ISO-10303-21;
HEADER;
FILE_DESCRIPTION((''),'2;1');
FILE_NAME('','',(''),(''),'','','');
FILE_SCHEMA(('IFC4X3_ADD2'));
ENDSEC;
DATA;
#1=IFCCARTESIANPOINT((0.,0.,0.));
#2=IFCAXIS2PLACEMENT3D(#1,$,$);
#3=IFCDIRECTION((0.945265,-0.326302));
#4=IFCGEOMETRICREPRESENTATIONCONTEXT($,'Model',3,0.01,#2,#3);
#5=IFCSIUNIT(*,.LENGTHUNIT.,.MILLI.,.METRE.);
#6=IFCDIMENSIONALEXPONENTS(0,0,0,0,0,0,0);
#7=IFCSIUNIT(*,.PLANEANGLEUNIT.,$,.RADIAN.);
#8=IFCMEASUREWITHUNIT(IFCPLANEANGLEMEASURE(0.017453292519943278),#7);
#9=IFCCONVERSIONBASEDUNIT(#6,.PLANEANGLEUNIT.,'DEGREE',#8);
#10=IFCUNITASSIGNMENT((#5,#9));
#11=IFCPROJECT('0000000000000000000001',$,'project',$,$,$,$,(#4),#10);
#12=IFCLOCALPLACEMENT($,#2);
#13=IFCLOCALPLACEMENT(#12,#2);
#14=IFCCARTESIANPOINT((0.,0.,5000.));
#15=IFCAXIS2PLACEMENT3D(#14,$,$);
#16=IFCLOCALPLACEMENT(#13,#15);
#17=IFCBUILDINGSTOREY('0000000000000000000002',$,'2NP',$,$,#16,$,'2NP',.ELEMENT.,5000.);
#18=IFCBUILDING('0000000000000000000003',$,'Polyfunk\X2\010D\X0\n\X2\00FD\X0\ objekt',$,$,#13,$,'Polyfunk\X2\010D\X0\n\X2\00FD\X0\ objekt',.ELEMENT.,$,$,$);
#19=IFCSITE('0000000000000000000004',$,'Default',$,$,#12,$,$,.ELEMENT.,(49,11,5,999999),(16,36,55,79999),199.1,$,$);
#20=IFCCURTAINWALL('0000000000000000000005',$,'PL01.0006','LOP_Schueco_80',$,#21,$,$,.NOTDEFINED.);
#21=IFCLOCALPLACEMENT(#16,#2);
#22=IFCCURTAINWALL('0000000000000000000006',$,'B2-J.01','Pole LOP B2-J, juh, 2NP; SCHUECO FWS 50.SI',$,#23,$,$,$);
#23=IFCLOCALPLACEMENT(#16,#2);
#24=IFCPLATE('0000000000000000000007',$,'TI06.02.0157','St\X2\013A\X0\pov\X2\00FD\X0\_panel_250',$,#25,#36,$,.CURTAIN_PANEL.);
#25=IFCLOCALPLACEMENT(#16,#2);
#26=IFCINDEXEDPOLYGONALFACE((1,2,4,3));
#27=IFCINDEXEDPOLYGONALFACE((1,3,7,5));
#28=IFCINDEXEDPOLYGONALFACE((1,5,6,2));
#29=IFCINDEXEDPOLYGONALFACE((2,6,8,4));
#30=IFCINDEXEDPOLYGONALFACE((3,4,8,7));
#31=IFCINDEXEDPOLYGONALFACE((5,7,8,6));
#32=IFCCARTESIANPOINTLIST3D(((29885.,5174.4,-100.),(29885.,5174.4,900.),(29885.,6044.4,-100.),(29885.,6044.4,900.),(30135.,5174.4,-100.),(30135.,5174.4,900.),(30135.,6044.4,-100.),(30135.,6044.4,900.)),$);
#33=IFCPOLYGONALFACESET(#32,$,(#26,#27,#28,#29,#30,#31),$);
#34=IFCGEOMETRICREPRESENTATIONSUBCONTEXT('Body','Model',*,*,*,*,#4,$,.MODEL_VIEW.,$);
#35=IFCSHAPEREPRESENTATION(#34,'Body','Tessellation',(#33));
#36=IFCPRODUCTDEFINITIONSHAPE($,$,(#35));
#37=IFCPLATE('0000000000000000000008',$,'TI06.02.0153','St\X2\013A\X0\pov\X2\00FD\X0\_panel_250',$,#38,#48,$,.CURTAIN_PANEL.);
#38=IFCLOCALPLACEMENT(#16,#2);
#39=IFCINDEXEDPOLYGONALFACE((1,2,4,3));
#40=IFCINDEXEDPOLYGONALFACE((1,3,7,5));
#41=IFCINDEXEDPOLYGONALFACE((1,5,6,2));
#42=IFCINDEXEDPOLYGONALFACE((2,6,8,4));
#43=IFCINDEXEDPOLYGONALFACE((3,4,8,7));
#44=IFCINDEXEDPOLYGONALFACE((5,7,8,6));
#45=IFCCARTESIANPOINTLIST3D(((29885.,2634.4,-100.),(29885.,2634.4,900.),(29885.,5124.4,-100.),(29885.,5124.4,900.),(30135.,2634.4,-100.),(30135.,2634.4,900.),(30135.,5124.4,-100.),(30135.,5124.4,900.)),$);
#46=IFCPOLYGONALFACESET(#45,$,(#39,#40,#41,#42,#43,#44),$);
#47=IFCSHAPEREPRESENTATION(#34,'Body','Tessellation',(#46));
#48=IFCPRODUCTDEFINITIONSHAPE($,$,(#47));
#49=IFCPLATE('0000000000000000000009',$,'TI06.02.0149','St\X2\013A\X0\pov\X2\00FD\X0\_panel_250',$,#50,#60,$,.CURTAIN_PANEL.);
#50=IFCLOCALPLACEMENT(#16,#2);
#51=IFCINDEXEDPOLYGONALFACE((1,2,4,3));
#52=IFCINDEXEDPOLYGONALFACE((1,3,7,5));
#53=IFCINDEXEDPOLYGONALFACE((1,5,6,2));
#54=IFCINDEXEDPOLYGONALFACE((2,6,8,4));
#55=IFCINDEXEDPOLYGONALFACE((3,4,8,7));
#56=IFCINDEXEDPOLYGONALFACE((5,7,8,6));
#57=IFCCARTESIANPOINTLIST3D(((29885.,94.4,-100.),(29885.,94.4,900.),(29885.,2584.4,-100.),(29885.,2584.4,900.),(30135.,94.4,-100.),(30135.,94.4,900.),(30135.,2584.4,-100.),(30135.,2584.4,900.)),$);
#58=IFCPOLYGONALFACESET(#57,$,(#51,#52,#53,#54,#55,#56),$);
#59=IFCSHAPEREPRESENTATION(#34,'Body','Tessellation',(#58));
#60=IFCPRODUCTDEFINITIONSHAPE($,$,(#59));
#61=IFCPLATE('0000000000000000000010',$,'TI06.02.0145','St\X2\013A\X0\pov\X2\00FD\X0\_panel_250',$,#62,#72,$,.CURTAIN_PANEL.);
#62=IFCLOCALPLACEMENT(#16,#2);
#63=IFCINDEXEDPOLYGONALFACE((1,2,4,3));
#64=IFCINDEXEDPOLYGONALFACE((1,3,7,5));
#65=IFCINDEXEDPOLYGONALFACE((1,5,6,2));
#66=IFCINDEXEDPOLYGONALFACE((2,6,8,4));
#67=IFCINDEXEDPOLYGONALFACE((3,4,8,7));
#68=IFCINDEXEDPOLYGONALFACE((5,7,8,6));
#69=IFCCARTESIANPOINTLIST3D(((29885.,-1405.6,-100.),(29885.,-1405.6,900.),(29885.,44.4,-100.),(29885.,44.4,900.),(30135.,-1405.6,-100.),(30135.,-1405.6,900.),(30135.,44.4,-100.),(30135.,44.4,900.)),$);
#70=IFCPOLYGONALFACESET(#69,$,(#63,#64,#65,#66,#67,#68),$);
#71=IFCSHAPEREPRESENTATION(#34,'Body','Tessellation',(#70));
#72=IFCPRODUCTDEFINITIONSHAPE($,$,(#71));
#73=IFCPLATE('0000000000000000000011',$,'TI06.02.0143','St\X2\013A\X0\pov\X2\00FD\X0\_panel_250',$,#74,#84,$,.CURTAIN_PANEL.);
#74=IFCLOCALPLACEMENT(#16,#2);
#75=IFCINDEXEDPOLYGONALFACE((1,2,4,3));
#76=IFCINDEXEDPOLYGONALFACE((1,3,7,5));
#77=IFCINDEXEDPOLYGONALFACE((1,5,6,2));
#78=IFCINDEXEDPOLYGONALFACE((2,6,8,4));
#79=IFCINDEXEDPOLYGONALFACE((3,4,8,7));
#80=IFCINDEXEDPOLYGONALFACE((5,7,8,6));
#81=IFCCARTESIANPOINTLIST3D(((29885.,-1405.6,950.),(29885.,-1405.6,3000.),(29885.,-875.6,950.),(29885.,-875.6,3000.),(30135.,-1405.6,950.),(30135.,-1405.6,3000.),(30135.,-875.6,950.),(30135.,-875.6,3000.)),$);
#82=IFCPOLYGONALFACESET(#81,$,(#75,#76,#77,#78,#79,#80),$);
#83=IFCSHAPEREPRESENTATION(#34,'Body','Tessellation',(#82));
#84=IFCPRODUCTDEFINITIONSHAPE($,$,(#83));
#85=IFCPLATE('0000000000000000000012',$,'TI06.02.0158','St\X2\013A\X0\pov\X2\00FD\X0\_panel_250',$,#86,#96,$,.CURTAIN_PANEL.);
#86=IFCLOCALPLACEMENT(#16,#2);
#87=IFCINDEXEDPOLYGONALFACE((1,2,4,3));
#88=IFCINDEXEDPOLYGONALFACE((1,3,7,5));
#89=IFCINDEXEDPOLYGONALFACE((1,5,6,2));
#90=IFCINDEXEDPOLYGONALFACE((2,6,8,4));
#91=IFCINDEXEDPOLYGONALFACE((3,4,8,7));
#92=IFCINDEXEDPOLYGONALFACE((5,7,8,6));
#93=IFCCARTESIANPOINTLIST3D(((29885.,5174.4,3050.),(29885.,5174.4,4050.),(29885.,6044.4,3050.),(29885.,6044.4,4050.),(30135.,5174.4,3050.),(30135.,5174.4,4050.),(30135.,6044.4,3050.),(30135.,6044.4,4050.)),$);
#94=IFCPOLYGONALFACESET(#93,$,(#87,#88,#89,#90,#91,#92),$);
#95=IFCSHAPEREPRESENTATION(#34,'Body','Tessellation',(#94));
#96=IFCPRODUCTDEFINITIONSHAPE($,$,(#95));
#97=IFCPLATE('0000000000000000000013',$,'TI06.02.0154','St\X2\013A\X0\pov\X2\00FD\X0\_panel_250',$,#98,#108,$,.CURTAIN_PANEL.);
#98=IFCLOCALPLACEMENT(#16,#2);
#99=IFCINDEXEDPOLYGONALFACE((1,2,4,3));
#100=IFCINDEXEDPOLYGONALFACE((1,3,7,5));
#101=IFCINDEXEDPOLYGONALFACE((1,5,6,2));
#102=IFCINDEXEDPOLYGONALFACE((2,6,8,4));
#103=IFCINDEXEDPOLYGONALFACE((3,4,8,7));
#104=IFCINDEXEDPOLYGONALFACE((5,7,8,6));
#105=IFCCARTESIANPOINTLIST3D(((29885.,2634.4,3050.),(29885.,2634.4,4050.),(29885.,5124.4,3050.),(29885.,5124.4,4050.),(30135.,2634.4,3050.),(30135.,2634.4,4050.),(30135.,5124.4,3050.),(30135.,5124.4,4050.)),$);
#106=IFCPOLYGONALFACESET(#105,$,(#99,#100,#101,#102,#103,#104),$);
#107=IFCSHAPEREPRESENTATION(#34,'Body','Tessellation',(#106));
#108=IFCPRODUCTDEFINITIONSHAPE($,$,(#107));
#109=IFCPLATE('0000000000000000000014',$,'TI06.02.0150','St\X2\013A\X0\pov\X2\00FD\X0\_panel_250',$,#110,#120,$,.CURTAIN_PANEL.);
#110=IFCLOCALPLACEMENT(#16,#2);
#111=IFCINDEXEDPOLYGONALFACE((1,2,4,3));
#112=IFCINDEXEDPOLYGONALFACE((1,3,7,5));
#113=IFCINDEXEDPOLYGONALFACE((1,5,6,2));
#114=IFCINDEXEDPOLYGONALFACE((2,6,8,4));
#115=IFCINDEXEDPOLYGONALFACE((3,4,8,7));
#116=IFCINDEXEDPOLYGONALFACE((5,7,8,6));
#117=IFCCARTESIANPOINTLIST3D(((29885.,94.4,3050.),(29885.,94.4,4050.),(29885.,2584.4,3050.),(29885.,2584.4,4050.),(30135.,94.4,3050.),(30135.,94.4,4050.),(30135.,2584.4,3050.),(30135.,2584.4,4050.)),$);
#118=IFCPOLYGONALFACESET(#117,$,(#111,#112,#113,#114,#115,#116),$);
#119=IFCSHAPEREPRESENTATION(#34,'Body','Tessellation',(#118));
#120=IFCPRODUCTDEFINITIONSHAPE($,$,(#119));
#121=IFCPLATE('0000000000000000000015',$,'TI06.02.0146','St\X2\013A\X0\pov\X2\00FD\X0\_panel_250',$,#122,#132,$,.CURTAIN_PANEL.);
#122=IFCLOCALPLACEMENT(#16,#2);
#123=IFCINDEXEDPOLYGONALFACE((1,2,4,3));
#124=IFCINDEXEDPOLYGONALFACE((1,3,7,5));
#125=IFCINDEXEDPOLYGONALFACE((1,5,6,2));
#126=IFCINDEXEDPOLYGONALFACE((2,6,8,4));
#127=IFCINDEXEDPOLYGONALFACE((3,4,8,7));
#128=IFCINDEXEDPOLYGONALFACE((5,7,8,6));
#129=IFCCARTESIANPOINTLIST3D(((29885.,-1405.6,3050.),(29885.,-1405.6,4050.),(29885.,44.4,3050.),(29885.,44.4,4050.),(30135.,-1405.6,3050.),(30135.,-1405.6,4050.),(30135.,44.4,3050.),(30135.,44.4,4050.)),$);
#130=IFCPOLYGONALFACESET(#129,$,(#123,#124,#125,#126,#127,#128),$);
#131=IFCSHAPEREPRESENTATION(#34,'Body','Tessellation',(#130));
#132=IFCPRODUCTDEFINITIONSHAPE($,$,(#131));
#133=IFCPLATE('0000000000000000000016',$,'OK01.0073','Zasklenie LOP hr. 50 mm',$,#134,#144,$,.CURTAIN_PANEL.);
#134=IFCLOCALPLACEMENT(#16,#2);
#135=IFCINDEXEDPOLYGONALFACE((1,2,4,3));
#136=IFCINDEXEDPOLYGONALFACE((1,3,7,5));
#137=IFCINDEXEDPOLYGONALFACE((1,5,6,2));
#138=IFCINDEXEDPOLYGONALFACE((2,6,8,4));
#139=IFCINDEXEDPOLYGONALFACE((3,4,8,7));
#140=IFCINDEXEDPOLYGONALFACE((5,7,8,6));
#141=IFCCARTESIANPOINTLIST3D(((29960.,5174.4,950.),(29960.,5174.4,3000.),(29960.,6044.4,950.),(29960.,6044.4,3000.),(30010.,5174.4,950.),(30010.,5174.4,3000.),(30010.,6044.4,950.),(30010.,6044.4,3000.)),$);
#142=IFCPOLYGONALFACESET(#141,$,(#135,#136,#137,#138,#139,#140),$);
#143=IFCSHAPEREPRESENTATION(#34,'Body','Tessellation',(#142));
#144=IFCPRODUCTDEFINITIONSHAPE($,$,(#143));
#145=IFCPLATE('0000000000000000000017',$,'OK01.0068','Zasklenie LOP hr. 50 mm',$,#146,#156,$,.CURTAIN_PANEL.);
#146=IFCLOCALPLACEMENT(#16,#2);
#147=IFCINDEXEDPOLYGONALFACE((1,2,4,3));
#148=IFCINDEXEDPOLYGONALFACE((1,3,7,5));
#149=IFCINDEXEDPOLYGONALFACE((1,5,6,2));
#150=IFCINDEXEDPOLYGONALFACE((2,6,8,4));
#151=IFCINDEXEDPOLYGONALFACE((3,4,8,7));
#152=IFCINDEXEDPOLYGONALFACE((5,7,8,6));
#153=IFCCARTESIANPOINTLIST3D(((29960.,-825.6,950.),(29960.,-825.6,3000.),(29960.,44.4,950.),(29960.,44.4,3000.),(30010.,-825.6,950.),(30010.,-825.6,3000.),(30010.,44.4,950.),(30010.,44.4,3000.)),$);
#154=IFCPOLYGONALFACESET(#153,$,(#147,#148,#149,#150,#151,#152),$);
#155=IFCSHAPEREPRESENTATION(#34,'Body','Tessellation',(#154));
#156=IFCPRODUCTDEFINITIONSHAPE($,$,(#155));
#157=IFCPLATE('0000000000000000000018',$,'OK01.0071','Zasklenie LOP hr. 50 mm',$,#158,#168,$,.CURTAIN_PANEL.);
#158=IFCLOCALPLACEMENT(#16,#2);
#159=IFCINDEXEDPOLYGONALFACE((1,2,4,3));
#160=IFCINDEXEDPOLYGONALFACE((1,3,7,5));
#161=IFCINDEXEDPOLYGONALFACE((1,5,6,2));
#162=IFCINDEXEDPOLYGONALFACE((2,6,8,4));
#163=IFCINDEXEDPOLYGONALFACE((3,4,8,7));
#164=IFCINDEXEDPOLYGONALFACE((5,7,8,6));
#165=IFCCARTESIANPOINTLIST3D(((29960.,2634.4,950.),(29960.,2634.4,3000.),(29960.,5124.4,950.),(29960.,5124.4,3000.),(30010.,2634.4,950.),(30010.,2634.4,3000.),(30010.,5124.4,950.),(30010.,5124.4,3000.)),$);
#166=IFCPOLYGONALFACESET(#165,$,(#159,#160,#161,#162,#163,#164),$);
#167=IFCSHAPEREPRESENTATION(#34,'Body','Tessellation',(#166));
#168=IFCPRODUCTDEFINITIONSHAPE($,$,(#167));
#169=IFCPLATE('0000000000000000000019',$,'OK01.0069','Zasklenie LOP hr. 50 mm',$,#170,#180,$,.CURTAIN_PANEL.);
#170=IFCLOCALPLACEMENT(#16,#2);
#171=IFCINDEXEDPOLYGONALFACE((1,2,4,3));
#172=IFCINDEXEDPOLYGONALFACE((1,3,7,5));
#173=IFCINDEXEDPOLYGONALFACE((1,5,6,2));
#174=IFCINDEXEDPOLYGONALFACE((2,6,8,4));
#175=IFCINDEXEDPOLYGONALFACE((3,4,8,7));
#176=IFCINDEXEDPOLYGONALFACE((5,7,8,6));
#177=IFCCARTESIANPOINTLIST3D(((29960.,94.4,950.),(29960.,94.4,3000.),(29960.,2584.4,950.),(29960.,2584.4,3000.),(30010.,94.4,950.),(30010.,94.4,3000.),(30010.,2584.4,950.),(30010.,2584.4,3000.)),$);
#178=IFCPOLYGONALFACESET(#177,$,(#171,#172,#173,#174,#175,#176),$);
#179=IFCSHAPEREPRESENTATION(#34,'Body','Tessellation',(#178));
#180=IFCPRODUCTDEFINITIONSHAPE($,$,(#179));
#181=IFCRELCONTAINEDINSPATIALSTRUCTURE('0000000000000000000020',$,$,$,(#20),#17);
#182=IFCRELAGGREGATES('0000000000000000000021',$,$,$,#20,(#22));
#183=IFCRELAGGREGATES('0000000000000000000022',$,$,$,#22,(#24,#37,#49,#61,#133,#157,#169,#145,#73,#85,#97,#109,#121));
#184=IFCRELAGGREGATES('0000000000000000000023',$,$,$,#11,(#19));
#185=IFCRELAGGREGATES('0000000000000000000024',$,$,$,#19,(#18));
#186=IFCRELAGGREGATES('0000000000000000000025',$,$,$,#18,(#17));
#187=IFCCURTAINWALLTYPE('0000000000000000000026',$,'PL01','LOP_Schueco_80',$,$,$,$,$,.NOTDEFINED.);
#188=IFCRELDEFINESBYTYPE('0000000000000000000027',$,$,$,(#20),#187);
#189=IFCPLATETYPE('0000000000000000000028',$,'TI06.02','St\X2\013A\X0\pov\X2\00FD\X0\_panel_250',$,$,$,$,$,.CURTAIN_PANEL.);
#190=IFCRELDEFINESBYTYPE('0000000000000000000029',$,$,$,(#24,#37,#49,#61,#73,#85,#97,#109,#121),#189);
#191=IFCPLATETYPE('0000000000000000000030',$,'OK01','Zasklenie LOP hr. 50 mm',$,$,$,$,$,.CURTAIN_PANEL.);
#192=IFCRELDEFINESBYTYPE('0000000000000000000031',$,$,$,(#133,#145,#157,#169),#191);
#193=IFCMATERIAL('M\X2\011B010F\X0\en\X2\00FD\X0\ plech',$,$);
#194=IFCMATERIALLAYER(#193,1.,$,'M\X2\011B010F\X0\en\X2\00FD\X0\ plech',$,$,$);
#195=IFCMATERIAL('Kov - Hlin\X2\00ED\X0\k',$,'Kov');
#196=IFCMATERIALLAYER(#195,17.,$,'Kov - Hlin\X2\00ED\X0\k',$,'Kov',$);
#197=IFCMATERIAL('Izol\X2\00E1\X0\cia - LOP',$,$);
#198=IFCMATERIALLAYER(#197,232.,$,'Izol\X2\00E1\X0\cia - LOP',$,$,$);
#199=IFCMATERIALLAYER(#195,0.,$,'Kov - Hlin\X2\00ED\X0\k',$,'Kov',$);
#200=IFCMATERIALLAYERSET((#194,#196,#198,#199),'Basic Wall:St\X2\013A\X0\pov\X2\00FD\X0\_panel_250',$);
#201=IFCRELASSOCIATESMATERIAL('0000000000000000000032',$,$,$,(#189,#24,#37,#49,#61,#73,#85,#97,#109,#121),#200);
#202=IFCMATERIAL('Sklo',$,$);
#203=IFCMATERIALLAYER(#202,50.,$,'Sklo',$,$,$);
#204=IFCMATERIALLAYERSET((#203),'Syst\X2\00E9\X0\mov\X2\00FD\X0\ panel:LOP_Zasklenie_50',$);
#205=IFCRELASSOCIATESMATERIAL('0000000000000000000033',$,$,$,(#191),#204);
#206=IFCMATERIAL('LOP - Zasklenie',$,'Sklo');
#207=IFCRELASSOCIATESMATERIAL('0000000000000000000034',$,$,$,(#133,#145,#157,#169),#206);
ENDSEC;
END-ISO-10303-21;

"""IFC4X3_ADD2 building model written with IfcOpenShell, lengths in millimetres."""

from ifc_helpers import new_model, entity, si_unit, converted_unit, direction, frame, frame_2d, origin, origin_2d_with_axis, place, context, subcontext, project, spatial, rectangle, extrude, source, transform, mapped, material, layer, layer_set, layer_usage, type_object, type_shapes, element, aggregate, save


model = new_model("IFC4X3_ADD2")

# Units and contexts
model_context = context("Model", 3, precision=0.01, world=origin(), true_north=direction((0.945265, -0.326302)))
body_context = subcontext(model_context, "Body", "Model", "MODEL_VIEW")
ifc_project = project(units=[si_unit("LENGTHUNIT", "METRE", prefix="MILLI"), converted_unit("PLANEANGLEUNIT", "DEGREE", entity("IfcPlaneAngleMeasure", 0.017453292519943278), si_unit("PLANEANGLEUNIT", "RADIAN"), dimensions=[0, 0, 0, 0, 0, 0, 0])], contexts=[model_context])

# Site, building, storey
site_placement = place(None, origin())
site = spatial("IfcSite", under=ifc_project, at=site_placement, Name="Default", CompositionType="ELEMENT", RefLatitude=(49, 11, 5, 999999), RefLongitude=(16, 36, 55, 79999), RefElevation=199.1)
building_placement = place(site_placement, origin())
building = spatial("IfcBuilding", under=site, at=building_placement, Name="Polyfunkčný objekt", LongName="Polyfunkčný objekt", CompositionType="ELEMENT")
storey_placement = place(building_placement, frame((0.0, 0.0, 5000.0)))
storey = spatial("IfcBuildingStorey", under=building, at=storey_placement, Name="2NP", LongName="2NP", CompositionType="ELEMENT", Elevation=5000.0)

# Curtain walls, plates
curtain_wall_type = type_object("IfcCurtainWallType", Name="PL01", Description="LOP_Schueco_80", PredefinedType="NOTDEFINED")
curtain_wall_1_placement = place(storey_placement, frame((0.0, 0.0, -5000.0)))
curtain_wall_1 = element("IfcCurtainWall", 1, at=curtain_wall_1_placement, inside=storey, type_object=curtain_wall_type, Name="PL01.0006", Description="LOP_Schueco_80", PredefinedType="NOTDEFINED")
curtain_wall_2 = element("IfcCurtainWall", 2, Name="B2-J.01", Description="Pole LOP B2-J, juh, 2NP; SCHUECO FWS 50.SI")
aggregate(curtain_wall_1, [curtain_wall_2])
ifc_material_1 = material(Name="Měďený plech")
ifc_layer_1 = layer(ifc_material_1, 1.0, Name="Měďený plech")
ifc_material_2 = material(Name="Kov - Hliník", Category="Kov")
ifc_layer_2 = layer(ifc_material_2, 17.0, Name="Kov - Hliník", Category="Kov")
ifc_material_3 = material(Name="Izolácia - LOP")
ifc_layer_3 = layer(ifc_material_3, 232.0, Name="Izolácia - LOP")
ifc_layer_4 = layer(ifc_material_2, 0.0, Name="Kov - Hliník", Category="Kov")
ifc_layer_set_1 = layer_set([ifc_layer_1, ifc_layer_2, ifc_layer_3, ifc_layer_4], Name="Basic Wall:Stĺpový_panel_250")
ifc_layer_usage_1 = layer_usage(ifc_layer_set_1, "AXIS2", "POSITIVE", -125.0)
plate_type_1 = type_object("IfcPlateType", Name="TI06.02", Description="Stĺpový_panel_250", PredefinedType="CURTAIN_PANEL", material=ifc_layer_set_1)
plate_1_placement = place(storey_placement, frame((30010.0, 6044.4, -100.0), z_axis=(0.0, 0.0, 1.0), x_axis=(0.0, -1.0, 0.0)))
plate_1 = element("IfcPlate", 3, at=plate_1_placement, type_object=plate_type_1, material=ifc_layer_usage_1, Name="TI06.02.0157", Description="Stĺpový_panel_250", PredefinedType="CURTAIN_PANEL", context=body_context, shape_type="SweptSolid", body=[
    extrude(rectangle(XDim=250.0, YDim=870.0, at=frame_2d((0.0, 0.0), x_axis=(1.0, 0.0))), frame((435.0, 0.0, 0.0), z_axis=(0.0, 0.0, 1.0), x_axis=(0.0, 1.0, 0.0)), (0.0, 0.0, 1.0), 1000.0),
])
ifc_layer_usage_2 = layer_usage(ifc_layer_set_1, "AXIS2", "POSITIVE", -125.0)
plate_2_placement = place(storey_placement, frame((30010.0, 5124.4, -100.0), z_axis=(0.0, 0.0, 1.0), x_axis=(0.0, -1.0, 0.0)))
plate_2 = element("IfcPlate", 4, at=plate_2_placement, type_object=plate_type_1, material=ifc_layer_usage_2, Name="TI06.02.0153", Description="Stĺpový_panel_250", PredefinedType="CURTAIN_PANEL", context=body_context, shape_type="SweptSolid", body=[
    extrude(rectangle(XDim=250.0, YDim=2490.0, at=frame_2d((0.0, 0.0), x_axis=(1.0, 0.0))), frame((1245.0, 0.0, 0.0), z_axis=(0.0, 0.0, 1.0), x_axis=(0.0, 1.0, 0.0)), (0.0, 0.0, 1.0), 1000.0),
])
ifc_layer_usage_3 = layer_usage(ifc_layer_set_1, "AXIS2", "POSITIVE", -125.0)
plate_3_placement = place(storey_placement, frame((30010.0, 2584.4, -100.0), z_axis=(0.0, 0.0, 1.0), x_axis=(0.0, -1.0, 0.0)))
plate_3 = element("IfcPlate", 5, at=plate_3_placement, type_object=plate_type_1, material=ifc_layer_usage_3, Name="TI06.02.0149", Description="Stĺpový_panel_250", PredefinedType="CURTAIN_PANEL", context=body_context, shape_type="SweptSolid", body=[
    extrude(rectangle(XDim=250.0, YDim=2490.0, at=frame_2d((0.0, 0.0), x_axis=(1.0, 0.0))), frame((1245.0, 0.0, 0.0), z_axis=(0.0, 0.0, 1.0), x_axis=(0.0, 1.0, 0.0)), (0.0, 0.0, 1.0), 1000.0),
])
ifc_layer_usage_4 = layer_usage(ifc_layer_set_1, "AXIS2", "POSITIVE", -125.0)
plate_4_placement = place(storey_placement, frame((30010.0, 44.4, -100.0), z_axis=(0.0, 0.0, 1.0), x_axis=(0.0, -1.0, 0.0)))
plate_4 = element("IfcPlate", 6, at=plate_4_placement, type_object=plate_type_1, material=ifc_layer_usage_4, Name="TI06.02.0145", Description="Stĺpový_panel_250", PredefinedType="CURTAIN_PANEL", context=body_context, shape_type="SweptSolid", body=[
    extrude(rectangle(XDim=250.0, YDim=1450.0, at=frame_2d((0.0, 0.0), x_axis=(1.0, 0.0))), frame((725.0, 0.0, 0.0), z_axis=(0.0, 0.0, 1.0), x_axis=(0.0, 1.0, 0.0)), (0.0, 0.0, 1.0), 1000.0),
])
ifc_layer_usage_5 = layer_usage(ifc_layer_set_1, "AXIS2", "POSITIVE", -125.0)
plate_5_placement = place(storey_placement, frame((30010.0, -875.6, 950.0), z_axis=(0.0, 0.0, 1.0), x_axis=(0.0, -1.0, 0.0)))
plate_5 = element("IfcPlate", 7, at=plate_5_placement, type_object=plate_type_1, material=ifc_layer_usage_5, Name="TI06.02.0143", Description="Stĺpový_panel_250", PredefinedType="CURTAIN_PANEL", context=body_context, shape_type="SweptSolid", body=[
    extrude(rectangle(XDim=250.0, YDim=530.0, at=frame_2d((0.0, 0.0), x_axis=(1.0, 0.0))), frame((265.0, 0.0, 0.0), z_axis=(0.0, 0.0, 1.0), x_axis=(0.0, 1.0, 0.0)), (0.0, 0.0, 1.0), 2050.0),
])
ifc_layer_usage_6 = layer_usage(ifc_layer_set_1, "AXIS2", "POSITIVE", -125.0)
plate_6_placement = place(storey_placement, frame((30010.0, 6044.4, 3050.0), z_axis=(0.0, 0.0, 1.0), x_axis=(0.0, -1.0, 0.0)))
plate_6 = element("IfcPlate", 8, at=plate_6_placement, type_object=plate_type_1, material=ifc_layer_usage_6, Name="TI06.02.0158", Description="Stĺpový_panel_250", PredefinedType="CURTAIN_PANEL", context=body_context, shape_type="SweptSolid", body=[
    extrude(rectangle(XDim=250.0, YDim=870.0, at=frame_2d((0.0, 0.0), x_axis=(1.0, 0.0))), frame((435.0, 0.0, 0.0), z_axis=(0.0, 0.0, 1.0), x_axis=(0.0, 1.0, 0.0)), (0.0, 0.0, 1.0), 1000.0),
])
ifc_layer_usage_7 = layer_usage(ifc_layer_set_1, "AXIS2", "POSITIVE", -125.0)
plate_7_placement = place(storey_placement, frame((30010.0, 5124.4, 3050.0), z_axis=(0.0, 0.0, 1.0), x_axis=(0.0, -1.0, 0.0)))
plate_7 = element("IfcPlate", 9, at=plate_7_placement, type_object=plate_type_1, material=ifc_layer_usage_7, Name="TI06.02.0154", Description="Stĺpový_panel_250", PredefinedType="CURTAIN_PANEL", context=body_context, shape_type="SweptSolid", body=[
    extrude(rectangle(XDim=250.0, YDim=2490.0, at=frame_2d((0.0, 0.0), x_axis=(1.0, 0.0))), frame((1245.0, 0.0, 0.0), z_axis=(0.0, 0.0, 1.0), x_axis=(0.0, 1.0, 0.0)), (0.0, 0.0, 1.0), 1000.0),
])
ifc_layer_usage_8 = layer_usage(ifc_layer_set_1, "AXIS2", "POSITIVE", -125.0)
plate_8_placement = place(storey_placement, frame((30010.0, 2584.4, 3050.0), z_axis=(0.0, 0.0, 1.0), x_axis=(0.0, -1.0, 0.0)))
plate_8 = element("IfcPlate", 10, at=plate_8_placement, type_object=plate_type_1, material=ifc_layer_usage_8, Name="TI06.02.0150", Description="Stĺpový_panel_250", PredefinedType="CURTAIN_PANEL", context=body_context, shape_type="SweptSolid", body=[
    extrude(rectangle(XDim=250.0, YDim=2490.0, at=frame_2d((0.0, 0.0), x_axis=(1.0, 0.0))), frame((1245.0, 0.0, 0.0), z_axis=(0.0, 0.0, 1.0), x_axis=(0.0, 1.0, 0.0)), (0.0, 0.0, 1.0), 1000.0),
])
ifc_layer_usage_9 = layer_usage(ifc_layer_set_1, "AXIS2", "POSITIVE", -125.0)
plate_9_placement = place(storey_placement, frame((30010.0, 44.4, 3050.0), z_axis=(0.0, 0.0, 1.0), x_axis=(0.0, -1.0, 0.0)))
plate_9 = element("IfcPlate", 11, at=plate_9_placement, type_object=plate_type_1, material=ifc_layer_usage_9, Name="TI06.02.0146", Description="Stĺpový_panel_250", PredefinedType="CURTAIN_PANEL", context=body_context, shape_type="SweptSolid", body=[
    extrude(rectangle(XDim=250.0, YDim=1450.0, at=frame_2d((0.0, 0.0), x_axis=(1.0, 0.0))), frame((725.0, 0.0, 0.0), z_axis=(0.0, 0.0, 1.0), x_axis=(0.0, 1.0, 0.0)), (0.0, 0.0, 1.0), 1000.0),
])
ifc_material_4 = material(Name="LOP - Zasklenie", Category="Sklo")
ifc_material_5 = material(Name="Sklo")
ifc_layer_5 = layer(ifc_material_5, 50.0, Name="Sklo")
ifc_layer_set_2 = layer_set([ifc_layer_5], Name="Systémový panel:LOP_Zasklenie_50")
plate_type_2 = type_object("IfcPlateType", Name="OK01", Description="Zasklenie LOP hr. 50 mm", PredefinedType="CURTAIN_PANEL", material=ifc_layer_set_2)
shared_shape_1 = source(origin(), body_context, "Body", "SweptSolid", [
    extrude(rectangle(XDim=50.0, YDim=870.0, at=origin_2d_with_axis()), frame((0.0, -25.0, 0.0), z_axis=(0.0, 0.0, 1.0), x_axis=(0.0, 1.0, 0.0)), (0.0, 0.0, 1.0), 2050.0),
])
plate_10_placement = place(curtain_wall_1_placement, frame((30010.0, 5609.4, 5950.0), z_axis=(0.0, 0.0, 1.0), x_axis=(0.0, -1.0, 0.0)))
plate_10 = element("IfcPlate", 12, at=plate_10_placement, type_object=plate_type_2, material=ifc_material_4, Name="OK01.0073", Description="Zasklenie LOP hr. 50 mm", PredefinedType="CURTAIN_PANEL", context=body_context, shape_type="MappedRepresentation", body=[
    mapped(shared_shape_1, transform((0.0, 0.0, 0.0), scale=1.0)),
])
plate_11_placement = place(curtain_wall_1_placement, frame((30010.0, -390.6, 5950.0), z_axis=(0.0, 0.0, 1.0), x_axis=(0.0, -1.0, 0.0)))
plate_11 = element("IfcPlate", 13, at=plate_11_placement, type_object=plate_type_2, material=ifc_material_4, Name="OK01.0068", Description="Zasklenie LOP hr. 50 mm", PredefinedType="CURTAIN_PANEL", context=body_context, shape_type="MappedRepresentation", body=[
    mapped(shared_shape_1, transform((0.0, 0.0, 0.0), scale=1.0)),
])
shared_shape_2 = source(origin(), body_context, "Body", "SweptSolid", [
    extrude(rectangle(XDim=50.0, YDim=2490.0, at=origin_2d_with_axis()), frame((0.0, -25.0, 0.0), z_axis=(0.0, 0.0, 1.0), x_axis=(0.0, 1.0, 0.0)), (0.0, 0.0, 1.0), 2050.0),
])
type_shapes(plate_type_2, [shared_shape_1, shared_shape_2])
plate_12_placement = place(curtain_wall_1_placement, frame((30010.0, 3879.4, 5950.0), z_axis=(0.0, 0.0, 1.0), x_axis=(0.0, -1.0, 0.0)))
plate_12 = element("IfcPlate", 14, at=plate_12_placement, type_object=plate_type_2, material=ifc_material_4, Name="OK01.0071", Description="Zasklenie LOP hr. 50 mm", PredefinedType="CURTAIN_PANEL", context=body_context, shape_type="MappedRepresentation", body=[
    mapped(shared_shape_2, transform((0.0, 0.0, 0.0), scale=1.0)),
])
plate_13_placement = place(curtain_wall_1_placement, frame((30010.0, 1339.4, 5950.0), z_axis=(0.0, 0.0, 1.0), x_axis=(0.0, -1.0, 0.0)))
plate_13 = element("IfcPlate", 15, at=plate_13_placement, type_object=plate_type_2, material=ifc_material_4, Name="OK01.0069", Description="Zasklenie LOP hr. 50 mm", PredefinedType="CURTAIN_PANEL", context=body_context, shape_type="MappedRepresentation", body=[
    mapped(shared_shape_2, transform((0.0, 0.0, 0.0), scale=1.0)),
])
aggregate(curtain_wall_2, [plate_1, plate_2, plate_3, plate_4, plate_10, plate_12, plate_13, plate_11, plate_5, plate_6, plate_7, plate_8, plate_9])

save(model, "model.ifc")
